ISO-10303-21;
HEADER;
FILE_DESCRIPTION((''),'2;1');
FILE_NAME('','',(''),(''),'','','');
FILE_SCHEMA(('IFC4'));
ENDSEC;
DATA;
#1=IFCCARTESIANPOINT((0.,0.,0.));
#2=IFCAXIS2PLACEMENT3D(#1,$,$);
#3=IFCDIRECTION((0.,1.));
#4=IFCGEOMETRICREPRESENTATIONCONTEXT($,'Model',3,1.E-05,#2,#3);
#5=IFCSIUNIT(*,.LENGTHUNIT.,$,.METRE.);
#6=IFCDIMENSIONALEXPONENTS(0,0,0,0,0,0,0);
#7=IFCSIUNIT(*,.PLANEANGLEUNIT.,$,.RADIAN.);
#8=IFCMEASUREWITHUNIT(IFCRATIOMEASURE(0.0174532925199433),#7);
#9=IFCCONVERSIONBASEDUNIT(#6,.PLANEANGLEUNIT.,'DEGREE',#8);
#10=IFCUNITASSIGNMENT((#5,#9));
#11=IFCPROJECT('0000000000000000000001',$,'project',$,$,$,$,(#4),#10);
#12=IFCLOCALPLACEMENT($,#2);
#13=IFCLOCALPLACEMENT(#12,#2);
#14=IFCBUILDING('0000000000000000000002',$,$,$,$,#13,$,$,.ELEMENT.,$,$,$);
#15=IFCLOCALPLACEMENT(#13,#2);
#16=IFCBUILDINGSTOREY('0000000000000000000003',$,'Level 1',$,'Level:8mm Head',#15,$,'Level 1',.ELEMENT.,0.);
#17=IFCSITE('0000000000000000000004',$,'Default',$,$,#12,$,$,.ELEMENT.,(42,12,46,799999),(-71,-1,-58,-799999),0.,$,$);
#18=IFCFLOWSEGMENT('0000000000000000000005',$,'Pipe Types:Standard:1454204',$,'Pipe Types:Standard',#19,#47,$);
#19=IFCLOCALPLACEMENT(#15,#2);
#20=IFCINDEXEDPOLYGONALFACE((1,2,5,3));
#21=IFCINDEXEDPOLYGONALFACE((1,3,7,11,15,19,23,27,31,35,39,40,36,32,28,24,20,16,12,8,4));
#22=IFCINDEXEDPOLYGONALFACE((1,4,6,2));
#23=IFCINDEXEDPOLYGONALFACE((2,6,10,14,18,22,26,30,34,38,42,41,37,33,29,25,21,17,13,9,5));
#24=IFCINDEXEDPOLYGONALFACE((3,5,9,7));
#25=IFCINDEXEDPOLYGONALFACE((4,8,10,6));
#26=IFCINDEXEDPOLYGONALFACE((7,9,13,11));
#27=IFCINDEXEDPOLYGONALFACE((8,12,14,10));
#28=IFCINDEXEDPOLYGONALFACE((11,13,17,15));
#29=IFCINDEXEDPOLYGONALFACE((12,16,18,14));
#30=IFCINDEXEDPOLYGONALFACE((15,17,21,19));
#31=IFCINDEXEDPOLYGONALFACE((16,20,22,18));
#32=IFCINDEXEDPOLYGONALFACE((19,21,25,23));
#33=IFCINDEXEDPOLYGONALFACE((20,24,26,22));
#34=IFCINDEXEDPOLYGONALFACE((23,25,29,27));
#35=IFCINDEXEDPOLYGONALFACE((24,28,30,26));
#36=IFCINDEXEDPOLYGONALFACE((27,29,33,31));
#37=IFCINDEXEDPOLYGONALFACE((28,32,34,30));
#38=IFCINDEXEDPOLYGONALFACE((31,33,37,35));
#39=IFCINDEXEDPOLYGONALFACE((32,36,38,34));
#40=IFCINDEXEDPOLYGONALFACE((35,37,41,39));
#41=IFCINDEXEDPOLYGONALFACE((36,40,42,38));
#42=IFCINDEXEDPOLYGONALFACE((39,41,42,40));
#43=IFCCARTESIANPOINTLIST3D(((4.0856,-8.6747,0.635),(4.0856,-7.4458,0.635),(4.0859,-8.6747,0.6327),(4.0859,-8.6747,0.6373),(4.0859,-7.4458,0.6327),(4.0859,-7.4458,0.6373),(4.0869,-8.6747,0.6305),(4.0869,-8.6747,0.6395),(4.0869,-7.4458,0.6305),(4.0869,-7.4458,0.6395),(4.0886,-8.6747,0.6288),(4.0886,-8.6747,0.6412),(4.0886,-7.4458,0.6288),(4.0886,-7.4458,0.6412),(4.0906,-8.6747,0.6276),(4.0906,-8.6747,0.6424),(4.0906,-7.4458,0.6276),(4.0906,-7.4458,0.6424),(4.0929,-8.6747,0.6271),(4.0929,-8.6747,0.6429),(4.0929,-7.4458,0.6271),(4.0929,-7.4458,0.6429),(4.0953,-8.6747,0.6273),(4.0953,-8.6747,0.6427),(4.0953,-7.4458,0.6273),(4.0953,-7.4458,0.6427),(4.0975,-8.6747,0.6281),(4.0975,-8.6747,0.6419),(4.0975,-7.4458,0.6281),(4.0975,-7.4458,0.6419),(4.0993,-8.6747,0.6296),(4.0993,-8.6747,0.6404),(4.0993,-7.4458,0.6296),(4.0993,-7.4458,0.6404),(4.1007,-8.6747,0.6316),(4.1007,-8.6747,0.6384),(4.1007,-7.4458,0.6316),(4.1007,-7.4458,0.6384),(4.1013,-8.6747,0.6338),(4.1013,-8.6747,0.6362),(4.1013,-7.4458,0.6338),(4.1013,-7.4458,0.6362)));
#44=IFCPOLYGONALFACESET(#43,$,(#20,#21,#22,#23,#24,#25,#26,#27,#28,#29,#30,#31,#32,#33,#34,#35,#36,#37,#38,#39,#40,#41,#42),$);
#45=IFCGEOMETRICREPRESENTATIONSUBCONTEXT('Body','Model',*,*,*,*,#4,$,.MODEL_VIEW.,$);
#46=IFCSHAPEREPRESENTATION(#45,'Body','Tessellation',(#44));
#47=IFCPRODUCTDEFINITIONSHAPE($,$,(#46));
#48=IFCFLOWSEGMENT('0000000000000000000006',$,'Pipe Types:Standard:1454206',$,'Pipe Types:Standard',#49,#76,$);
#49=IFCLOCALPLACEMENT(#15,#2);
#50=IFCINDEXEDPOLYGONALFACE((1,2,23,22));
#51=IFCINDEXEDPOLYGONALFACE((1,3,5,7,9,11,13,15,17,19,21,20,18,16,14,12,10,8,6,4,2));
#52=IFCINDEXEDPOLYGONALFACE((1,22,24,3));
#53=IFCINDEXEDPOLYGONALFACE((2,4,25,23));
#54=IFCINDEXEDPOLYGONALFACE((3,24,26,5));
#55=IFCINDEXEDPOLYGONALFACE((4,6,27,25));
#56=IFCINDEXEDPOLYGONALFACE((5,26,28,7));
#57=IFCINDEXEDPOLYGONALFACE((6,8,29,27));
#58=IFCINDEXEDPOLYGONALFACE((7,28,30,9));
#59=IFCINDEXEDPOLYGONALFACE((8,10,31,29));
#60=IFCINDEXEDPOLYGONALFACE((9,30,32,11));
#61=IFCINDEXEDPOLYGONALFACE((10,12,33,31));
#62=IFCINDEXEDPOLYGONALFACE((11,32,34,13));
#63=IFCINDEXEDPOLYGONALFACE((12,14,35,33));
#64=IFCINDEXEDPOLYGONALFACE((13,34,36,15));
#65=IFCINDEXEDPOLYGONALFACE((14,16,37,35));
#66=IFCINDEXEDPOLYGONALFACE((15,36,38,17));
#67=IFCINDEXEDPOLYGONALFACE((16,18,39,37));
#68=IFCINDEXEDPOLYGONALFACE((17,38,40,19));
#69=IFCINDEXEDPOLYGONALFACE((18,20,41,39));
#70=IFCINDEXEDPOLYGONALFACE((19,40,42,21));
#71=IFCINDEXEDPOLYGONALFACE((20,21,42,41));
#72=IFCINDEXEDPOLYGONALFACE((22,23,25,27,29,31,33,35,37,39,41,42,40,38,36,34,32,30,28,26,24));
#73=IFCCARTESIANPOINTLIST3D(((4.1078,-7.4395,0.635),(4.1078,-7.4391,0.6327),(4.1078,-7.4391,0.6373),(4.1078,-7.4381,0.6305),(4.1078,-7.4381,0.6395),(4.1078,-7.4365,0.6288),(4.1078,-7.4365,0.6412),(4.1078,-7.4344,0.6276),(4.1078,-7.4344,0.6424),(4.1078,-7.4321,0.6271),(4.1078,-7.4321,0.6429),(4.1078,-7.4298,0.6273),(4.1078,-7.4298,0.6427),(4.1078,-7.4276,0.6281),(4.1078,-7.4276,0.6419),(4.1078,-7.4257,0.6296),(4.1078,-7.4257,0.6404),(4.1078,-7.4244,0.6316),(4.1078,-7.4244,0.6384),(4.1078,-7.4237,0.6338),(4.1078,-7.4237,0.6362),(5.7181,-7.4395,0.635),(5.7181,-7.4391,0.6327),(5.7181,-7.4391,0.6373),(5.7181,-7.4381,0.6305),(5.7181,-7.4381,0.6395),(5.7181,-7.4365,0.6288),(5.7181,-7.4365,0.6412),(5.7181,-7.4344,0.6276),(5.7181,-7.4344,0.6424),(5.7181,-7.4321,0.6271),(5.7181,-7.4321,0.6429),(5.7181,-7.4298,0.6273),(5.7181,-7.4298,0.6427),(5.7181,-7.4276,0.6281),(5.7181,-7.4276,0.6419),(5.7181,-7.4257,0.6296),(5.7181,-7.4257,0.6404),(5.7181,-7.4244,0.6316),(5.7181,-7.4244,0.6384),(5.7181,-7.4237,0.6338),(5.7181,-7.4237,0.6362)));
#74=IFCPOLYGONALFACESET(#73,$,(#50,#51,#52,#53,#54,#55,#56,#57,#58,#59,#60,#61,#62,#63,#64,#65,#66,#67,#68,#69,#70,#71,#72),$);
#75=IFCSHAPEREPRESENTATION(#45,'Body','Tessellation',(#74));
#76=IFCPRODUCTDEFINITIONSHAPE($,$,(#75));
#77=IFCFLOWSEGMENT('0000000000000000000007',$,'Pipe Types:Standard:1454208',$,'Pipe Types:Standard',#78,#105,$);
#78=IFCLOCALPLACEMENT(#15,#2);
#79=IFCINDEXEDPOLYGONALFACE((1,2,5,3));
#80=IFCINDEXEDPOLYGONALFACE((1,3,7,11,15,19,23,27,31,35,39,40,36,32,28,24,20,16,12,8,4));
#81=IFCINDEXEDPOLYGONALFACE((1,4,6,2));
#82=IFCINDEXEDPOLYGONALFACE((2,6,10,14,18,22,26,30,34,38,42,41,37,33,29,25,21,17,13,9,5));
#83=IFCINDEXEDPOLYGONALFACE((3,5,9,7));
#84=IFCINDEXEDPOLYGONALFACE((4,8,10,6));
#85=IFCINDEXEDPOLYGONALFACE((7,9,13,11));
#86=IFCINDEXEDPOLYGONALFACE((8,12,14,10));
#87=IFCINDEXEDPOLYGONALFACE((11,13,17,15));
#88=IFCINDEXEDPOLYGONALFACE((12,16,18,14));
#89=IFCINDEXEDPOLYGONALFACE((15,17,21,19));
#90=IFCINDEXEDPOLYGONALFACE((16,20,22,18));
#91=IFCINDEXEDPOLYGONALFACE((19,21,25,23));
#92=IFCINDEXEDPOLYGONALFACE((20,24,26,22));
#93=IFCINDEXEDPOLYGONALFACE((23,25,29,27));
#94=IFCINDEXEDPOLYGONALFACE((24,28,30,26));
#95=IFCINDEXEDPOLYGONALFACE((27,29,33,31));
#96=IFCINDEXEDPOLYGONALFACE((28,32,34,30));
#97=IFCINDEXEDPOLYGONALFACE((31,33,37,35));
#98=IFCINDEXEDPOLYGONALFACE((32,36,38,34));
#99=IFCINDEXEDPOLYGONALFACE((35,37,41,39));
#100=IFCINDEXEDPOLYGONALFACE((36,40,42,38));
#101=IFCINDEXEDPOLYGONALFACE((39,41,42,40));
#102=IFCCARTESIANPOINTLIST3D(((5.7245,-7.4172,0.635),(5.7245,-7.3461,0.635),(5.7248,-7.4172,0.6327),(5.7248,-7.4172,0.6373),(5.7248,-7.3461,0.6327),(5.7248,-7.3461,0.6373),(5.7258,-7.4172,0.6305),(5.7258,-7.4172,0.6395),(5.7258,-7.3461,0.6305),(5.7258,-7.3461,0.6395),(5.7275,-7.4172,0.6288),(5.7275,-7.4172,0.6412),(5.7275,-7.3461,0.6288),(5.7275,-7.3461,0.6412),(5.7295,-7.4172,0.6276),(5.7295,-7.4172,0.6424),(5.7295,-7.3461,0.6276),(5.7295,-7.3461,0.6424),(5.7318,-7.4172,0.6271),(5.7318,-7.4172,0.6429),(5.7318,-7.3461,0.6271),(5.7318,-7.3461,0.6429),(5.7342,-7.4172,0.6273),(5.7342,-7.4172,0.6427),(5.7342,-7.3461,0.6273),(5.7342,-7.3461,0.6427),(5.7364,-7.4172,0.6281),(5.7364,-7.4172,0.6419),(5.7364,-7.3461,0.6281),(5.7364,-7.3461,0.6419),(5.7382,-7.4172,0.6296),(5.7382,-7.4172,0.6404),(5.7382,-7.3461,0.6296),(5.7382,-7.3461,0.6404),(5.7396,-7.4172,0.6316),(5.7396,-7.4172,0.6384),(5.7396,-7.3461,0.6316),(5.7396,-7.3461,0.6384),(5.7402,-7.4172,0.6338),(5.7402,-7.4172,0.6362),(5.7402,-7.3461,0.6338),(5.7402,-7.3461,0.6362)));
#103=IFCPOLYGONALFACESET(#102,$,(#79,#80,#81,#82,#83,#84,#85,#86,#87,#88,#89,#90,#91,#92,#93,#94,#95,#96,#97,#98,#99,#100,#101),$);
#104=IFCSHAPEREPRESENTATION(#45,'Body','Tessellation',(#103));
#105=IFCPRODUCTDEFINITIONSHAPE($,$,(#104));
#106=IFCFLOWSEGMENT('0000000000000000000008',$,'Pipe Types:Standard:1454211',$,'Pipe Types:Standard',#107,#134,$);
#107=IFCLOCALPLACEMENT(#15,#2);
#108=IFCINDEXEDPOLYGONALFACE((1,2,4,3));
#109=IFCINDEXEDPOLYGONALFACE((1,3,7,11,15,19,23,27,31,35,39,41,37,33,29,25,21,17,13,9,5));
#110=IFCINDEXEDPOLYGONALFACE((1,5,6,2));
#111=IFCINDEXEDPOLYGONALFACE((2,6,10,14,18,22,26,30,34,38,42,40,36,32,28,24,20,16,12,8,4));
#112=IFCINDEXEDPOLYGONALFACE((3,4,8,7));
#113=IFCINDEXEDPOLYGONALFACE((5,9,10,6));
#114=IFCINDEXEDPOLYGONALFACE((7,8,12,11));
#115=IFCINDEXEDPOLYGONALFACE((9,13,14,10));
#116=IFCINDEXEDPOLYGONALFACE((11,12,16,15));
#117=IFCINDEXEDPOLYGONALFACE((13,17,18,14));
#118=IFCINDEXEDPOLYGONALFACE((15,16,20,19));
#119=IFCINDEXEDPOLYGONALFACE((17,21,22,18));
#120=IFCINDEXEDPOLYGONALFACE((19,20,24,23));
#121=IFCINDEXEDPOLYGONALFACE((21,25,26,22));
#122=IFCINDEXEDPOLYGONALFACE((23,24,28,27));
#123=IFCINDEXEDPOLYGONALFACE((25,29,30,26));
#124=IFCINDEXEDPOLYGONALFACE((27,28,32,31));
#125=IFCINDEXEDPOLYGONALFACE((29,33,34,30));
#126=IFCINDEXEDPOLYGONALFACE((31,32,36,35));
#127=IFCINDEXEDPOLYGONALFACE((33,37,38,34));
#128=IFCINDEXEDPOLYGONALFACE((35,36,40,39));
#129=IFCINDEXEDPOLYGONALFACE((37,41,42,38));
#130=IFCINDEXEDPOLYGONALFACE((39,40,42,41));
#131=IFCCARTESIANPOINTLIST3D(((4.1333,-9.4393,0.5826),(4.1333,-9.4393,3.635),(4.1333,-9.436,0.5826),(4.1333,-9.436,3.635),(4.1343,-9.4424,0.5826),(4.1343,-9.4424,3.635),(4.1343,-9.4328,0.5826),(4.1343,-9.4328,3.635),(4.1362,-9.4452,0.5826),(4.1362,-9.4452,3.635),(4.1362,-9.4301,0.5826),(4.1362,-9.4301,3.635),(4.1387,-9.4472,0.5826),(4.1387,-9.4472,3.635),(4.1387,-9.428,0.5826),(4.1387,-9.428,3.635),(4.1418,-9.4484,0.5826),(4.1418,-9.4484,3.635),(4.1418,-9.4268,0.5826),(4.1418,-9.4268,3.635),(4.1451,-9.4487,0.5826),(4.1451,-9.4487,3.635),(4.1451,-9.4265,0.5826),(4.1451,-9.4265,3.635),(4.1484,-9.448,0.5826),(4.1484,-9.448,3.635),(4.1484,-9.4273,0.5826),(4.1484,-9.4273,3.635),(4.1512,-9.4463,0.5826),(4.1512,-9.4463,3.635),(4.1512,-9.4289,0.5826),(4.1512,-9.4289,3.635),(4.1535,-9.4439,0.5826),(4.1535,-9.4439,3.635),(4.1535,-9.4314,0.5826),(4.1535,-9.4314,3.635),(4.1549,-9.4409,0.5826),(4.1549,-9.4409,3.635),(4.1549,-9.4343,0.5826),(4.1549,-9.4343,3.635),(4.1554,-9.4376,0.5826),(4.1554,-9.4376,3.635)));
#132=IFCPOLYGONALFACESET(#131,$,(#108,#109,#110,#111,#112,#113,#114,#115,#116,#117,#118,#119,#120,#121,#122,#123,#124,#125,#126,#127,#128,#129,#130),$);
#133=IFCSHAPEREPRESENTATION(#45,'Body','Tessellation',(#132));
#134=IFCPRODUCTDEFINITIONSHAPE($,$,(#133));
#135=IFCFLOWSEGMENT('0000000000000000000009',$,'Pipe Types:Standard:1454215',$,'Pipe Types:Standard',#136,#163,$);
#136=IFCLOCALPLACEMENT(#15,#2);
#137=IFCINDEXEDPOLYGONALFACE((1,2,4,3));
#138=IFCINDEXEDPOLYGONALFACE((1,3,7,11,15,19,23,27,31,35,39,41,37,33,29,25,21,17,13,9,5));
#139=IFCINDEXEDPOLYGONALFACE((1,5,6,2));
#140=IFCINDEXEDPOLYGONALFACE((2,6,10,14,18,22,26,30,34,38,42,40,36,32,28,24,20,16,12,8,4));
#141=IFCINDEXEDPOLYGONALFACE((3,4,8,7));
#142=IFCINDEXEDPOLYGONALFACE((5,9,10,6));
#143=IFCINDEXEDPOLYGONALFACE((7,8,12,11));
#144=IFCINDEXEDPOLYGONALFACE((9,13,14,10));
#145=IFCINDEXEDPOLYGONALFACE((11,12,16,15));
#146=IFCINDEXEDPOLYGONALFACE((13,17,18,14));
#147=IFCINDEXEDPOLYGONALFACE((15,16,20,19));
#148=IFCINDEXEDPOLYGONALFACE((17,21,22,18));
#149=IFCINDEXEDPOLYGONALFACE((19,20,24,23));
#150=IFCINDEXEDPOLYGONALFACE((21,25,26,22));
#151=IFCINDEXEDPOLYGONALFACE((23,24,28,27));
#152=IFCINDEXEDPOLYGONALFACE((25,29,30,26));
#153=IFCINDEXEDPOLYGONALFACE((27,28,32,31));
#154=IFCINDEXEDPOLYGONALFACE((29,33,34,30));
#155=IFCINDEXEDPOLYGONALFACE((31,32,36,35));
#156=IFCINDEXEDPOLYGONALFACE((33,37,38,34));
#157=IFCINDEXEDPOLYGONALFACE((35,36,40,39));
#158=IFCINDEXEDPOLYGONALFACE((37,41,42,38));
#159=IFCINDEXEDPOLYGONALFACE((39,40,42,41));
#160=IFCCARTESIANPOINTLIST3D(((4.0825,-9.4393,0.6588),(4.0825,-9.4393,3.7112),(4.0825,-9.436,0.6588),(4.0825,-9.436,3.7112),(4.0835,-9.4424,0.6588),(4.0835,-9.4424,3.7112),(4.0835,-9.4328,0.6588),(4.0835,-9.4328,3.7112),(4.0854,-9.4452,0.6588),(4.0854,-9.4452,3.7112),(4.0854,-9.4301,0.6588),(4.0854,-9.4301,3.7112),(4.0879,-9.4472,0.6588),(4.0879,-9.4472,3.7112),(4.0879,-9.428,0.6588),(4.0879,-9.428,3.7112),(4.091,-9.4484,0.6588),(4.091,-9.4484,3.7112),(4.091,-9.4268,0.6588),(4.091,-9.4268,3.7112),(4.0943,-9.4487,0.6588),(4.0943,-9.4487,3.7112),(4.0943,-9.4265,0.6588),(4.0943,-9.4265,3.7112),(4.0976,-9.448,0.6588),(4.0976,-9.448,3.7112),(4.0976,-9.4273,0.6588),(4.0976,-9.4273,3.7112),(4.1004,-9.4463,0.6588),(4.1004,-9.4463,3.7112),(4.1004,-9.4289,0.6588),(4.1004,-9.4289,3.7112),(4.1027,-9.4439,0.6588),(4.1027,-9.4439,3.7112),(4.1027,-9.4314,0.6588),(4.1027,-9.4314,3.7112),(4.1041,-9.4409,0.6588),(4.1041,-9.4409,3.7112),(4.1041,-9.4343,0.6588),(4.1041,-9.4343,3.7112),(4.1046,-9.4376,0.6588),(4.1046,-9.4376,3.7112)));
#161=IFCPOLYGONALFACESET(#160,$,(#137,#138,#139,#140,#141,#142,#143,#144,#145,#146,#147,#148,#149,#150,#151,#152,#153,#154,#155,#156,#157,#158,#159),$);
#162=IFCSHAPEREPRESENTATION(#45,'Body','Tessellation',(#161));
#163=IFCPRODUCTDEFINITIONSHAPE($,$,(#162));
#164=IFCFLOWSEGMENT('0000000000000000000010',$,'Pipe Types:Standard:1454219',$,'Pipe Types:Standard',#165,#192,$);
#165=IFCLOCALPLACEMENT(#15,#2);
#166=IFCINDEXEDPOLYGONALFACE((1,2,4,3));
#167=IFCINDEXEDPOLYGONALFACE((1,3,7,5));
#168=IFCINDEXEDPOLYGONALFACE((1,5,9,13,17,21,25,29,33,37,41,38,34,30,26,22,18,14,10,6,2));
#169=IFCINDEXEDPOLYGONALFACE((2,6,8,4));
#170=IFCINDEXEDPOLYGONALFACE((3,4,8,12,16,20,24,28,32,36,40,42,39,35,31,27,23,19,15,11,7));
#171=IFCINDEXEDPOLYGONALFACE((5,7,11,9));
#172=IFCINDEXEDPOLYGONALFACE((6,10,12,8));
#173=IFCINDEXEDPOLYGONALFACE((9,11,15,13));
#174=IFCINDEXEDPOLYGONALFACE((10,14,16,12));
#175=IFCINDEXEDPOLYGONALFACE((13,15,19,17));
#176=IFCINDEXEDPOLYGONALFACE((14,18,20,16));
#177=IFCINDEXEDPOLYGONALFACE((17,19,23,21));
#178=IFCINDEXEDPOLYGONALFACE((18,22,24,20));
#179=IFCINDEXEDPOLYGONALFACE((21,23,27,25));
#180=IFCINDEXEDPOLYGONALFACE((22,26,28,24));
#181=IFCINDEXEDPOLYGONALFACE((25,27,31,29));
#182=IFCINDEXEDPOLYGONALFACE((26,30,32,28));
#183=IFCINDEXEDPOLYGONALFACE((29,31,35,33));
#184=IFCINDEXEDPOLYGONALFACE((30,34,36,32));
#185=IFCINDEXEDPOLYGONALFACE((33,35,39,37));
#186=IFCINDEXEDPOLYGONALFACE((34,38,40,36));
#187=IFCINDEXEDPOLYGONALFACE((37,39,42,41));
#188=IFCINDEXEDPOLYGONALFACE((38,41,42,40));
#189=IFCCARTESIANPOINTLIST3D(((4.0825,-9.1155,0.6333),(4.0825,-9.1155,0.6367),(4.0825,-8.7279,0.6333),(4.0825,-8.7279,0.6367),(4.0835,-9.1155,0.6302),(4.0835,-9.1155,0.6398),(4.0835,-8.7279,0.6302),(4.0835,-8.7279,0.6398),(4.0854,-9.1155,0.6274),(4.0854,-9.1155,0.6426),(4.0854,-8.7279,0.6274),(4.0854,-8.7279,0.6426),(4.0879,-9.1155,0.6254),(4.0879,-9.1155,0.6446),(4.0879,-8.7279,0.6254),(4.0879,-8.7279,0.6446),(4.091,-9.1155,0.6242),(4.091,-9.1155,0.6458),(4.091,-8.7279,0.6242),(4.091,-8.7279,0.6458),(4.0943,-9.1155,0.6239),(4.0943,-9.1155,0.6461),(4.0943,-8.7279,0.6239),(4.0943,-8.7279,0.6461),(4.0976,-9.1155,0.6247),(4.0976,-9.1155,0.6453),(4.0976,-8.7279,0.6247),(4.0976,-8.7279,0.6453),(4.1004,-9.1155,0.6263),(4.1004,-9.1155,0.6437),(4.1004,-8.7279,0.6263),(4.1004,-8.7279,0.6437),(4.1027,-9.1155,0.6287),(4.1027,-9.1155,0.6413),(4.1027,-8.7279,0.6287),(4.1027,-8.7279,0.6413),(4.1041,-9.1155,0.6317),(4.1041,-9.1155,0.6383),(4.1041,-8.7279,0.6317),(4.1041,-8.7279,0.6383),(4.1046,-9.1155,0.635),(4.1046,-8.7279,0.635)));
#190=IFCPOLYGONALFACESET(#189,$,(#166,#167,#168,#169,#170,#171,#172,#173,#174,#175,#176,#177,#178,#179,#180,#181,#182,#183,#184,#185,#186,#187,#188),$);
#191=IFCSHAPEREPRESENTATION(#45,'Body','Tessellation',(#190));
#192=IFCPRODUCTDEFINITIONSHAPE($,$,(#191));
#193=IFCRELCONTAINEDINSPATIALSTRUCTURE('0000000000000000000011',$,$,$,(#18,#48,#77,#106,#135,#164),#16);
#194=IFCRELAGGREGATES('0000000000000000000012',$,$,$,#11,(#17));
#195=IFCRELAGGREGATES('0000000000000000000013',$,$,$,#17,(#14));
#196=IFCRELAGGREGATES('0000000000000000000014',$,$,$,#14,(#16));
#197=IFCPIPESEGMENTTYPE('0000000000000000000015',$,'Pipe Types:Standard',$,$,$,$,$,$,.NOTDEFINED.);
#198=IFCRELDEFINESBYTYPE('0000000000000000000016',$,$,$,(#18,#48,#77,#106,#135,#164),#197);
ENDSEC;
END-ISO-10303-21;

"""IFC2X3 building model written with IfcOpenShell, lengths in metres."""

from ifc_helpers import new_model, entity, si_unit, converted_unit, direction, frame, frame_2d, origin, origin_2d_with_axis, place, context, subcontext, project, spatial, circle, extrude, type_object, element, save


model = new_model("IFC2X3")

# Units and contexts
model_context = context("Model", 3, precision=1e-05, world=origin(), true_north=direction((0.0, 1.0)))
body_context = subcontext(model_context, "Body", "Model", "MODEL_VIEW")
ifc_project = project(units=[si_unit("LENGTHUNIT", "METRE"), converted_unit("PLANEANGLEUNIT", "DEGREE", entity("IfcRatioMeasure", 0.0174532925199433), si_unit("PLANEANGLEUNIT", "RADIAN"), dimensions=[0, 0, 0, 0, 0, 0, 0])], contexts=[model_context])

# Site, building, storey
site_placement = place(None, origin())
site = spatial("IfcSite", under=ifc_project, at=site_placement, Name="Default", CompositionType="ELEMENT", RefLatitude=(42, 12, 46, 799999), RefLongitude=(-71, -1, -58, -799999), RefElevation=0.0)
building_placement = place(site_placement, origin())
building = spatial("IfcBuilding", under=site, at=building_placement, CompositionType="ELEMENT")
storey_placement = place(building_placement, origin())
storey = spatial("IfcBuildingStorey", under=building, at=storey_placement, Name="Level 1", ObjectType="Level:8mm Head", LongName="Level 1", CompositionType="ELEMENT", Elevation=0.0)

# Flow segments
pipe_segment_type = type_object("IfcPipeSegmentType", Name="Pipe Types:Standard", PredefinedType="NOTDEFINED")
flow_segment_1_placement = place(storey_placement, origin())
element("IfcFlowSegment", 1, at=flow_segment_1_placement, inside=storey, type_object=pipe_segment_type, Name="Pipe Types:Standard:1454204", ObjectType="Pipe Types:Standard", context=body_context, shape_type="SweptSolid", body=[
    extrude(circle(Radius=0.0079, at=frame_2d((0.0, 0.0), x_axis=(1.0, 0.0))), frame((4.0935, -8.6747, 0.635), z_axis=(0.0, 1.0, 0.0), x_axis=(-1.0, 0.0, 0.0)), (0.0, 0.0, 1.0), 1.2289),
])
flow_segment_2_placement = place(storey_placement, origin())
element("IfcFlowSegment", 2, at=flow_segment_2_placement, inside=storey, type_object=pipe_segment_type, Name="Pipe Types:Standard:1454206", ObjectType="Pipe Types:Standard", context=body_context, shape_type="SweptSolid", body=[
    extrude(circle(Radius=0.0079, at=origin_2d_with_axis()), frame((4.1078, -7.4315, 0.635), z_axis=(1.0, 0.0, 0.0), x_axis=(0.0, -1.0, 0.0)), (0.0, 0.0, 1.0), 1.6103),
])
flow_segment_3_placement = place(storey_placement, origin())
element("IfcFlowSegment", 3, at=flow_segment_3_placement, inside=storey, type_object=pipe_segment_type, Name="Pipe Types:Standard:1454208", ObjectType="Pipe Types:Standard", context=body_context, shape_type="SweptSolid", body=[
    extrude(circle(Radius=0.0079, at=frame_2d((0.0, 0.0), x_axis=(1.0, 0.0))), frame((5.7324, -7.4172, 0.635), z_axis=(0.0, 1.0, 0.0), x_axis=(-1.0, 0.0, 0.0)), (0.0, 0.0, 1.0), 0.0712),
])
flow_segment_4_placement = place(storey_placement, origin())
element("IfcFlowSegment", 4, at=flow_segment_4_placement, inside=storey, type_object=pipe_segment_type, Name="Pipe Types:Standard:1454211", ObjectType="Pipe Types:Standard", context=body_context, shape_type="SweptSolid", body=[
    extrude(circle(Radius=0.0111, at=origin_2d_with_axis()), frame((4.1443, -9.4376, 0.5826)), (0.0, 0.0, 1.0), 3.0524),
])
flow_segment_5_placement = place(storey_placement, origin())
element("IfcFlowSegment", 5, at=flow_segment_5_placement, inside=storey, type_object=pipe_segment_type, Name="Pipe Types:Standard:1454215", ObjectType="Pipe Types:Standard", context=body_context, shape_type="SweptSolid", body=[
    extrude(circle(Radius=0.0111, at=origin_2d_with_axis()), frame((4.0935, -9.4376, 0.6588)), (0.0, 0.0, 1.0), 3.0524),
])
flow_segment_6_placement = place(storey_placement, origin())
element("IfcFlowSegment", 6, at=flow_segment_6_placement, inside=storey, type_object=pipe_segment_type, Name="Pipe Types:Standard:1454219", ObjectType="Pipe Types:Standard", context=body_context, shape_type="SweptSolid", body=[
    extrude(circle(Radius=0.0111, at=origin_2d_with_axis()), frame((4.0935, -9.1155, 0.635), z_axis=(0.0, 1.0, 0.0), x_axis=(1.0, 0.0, 0.0)), (0.0, 0.0, 1.0), 0.3877),
])

save(model, "model.ifc")
